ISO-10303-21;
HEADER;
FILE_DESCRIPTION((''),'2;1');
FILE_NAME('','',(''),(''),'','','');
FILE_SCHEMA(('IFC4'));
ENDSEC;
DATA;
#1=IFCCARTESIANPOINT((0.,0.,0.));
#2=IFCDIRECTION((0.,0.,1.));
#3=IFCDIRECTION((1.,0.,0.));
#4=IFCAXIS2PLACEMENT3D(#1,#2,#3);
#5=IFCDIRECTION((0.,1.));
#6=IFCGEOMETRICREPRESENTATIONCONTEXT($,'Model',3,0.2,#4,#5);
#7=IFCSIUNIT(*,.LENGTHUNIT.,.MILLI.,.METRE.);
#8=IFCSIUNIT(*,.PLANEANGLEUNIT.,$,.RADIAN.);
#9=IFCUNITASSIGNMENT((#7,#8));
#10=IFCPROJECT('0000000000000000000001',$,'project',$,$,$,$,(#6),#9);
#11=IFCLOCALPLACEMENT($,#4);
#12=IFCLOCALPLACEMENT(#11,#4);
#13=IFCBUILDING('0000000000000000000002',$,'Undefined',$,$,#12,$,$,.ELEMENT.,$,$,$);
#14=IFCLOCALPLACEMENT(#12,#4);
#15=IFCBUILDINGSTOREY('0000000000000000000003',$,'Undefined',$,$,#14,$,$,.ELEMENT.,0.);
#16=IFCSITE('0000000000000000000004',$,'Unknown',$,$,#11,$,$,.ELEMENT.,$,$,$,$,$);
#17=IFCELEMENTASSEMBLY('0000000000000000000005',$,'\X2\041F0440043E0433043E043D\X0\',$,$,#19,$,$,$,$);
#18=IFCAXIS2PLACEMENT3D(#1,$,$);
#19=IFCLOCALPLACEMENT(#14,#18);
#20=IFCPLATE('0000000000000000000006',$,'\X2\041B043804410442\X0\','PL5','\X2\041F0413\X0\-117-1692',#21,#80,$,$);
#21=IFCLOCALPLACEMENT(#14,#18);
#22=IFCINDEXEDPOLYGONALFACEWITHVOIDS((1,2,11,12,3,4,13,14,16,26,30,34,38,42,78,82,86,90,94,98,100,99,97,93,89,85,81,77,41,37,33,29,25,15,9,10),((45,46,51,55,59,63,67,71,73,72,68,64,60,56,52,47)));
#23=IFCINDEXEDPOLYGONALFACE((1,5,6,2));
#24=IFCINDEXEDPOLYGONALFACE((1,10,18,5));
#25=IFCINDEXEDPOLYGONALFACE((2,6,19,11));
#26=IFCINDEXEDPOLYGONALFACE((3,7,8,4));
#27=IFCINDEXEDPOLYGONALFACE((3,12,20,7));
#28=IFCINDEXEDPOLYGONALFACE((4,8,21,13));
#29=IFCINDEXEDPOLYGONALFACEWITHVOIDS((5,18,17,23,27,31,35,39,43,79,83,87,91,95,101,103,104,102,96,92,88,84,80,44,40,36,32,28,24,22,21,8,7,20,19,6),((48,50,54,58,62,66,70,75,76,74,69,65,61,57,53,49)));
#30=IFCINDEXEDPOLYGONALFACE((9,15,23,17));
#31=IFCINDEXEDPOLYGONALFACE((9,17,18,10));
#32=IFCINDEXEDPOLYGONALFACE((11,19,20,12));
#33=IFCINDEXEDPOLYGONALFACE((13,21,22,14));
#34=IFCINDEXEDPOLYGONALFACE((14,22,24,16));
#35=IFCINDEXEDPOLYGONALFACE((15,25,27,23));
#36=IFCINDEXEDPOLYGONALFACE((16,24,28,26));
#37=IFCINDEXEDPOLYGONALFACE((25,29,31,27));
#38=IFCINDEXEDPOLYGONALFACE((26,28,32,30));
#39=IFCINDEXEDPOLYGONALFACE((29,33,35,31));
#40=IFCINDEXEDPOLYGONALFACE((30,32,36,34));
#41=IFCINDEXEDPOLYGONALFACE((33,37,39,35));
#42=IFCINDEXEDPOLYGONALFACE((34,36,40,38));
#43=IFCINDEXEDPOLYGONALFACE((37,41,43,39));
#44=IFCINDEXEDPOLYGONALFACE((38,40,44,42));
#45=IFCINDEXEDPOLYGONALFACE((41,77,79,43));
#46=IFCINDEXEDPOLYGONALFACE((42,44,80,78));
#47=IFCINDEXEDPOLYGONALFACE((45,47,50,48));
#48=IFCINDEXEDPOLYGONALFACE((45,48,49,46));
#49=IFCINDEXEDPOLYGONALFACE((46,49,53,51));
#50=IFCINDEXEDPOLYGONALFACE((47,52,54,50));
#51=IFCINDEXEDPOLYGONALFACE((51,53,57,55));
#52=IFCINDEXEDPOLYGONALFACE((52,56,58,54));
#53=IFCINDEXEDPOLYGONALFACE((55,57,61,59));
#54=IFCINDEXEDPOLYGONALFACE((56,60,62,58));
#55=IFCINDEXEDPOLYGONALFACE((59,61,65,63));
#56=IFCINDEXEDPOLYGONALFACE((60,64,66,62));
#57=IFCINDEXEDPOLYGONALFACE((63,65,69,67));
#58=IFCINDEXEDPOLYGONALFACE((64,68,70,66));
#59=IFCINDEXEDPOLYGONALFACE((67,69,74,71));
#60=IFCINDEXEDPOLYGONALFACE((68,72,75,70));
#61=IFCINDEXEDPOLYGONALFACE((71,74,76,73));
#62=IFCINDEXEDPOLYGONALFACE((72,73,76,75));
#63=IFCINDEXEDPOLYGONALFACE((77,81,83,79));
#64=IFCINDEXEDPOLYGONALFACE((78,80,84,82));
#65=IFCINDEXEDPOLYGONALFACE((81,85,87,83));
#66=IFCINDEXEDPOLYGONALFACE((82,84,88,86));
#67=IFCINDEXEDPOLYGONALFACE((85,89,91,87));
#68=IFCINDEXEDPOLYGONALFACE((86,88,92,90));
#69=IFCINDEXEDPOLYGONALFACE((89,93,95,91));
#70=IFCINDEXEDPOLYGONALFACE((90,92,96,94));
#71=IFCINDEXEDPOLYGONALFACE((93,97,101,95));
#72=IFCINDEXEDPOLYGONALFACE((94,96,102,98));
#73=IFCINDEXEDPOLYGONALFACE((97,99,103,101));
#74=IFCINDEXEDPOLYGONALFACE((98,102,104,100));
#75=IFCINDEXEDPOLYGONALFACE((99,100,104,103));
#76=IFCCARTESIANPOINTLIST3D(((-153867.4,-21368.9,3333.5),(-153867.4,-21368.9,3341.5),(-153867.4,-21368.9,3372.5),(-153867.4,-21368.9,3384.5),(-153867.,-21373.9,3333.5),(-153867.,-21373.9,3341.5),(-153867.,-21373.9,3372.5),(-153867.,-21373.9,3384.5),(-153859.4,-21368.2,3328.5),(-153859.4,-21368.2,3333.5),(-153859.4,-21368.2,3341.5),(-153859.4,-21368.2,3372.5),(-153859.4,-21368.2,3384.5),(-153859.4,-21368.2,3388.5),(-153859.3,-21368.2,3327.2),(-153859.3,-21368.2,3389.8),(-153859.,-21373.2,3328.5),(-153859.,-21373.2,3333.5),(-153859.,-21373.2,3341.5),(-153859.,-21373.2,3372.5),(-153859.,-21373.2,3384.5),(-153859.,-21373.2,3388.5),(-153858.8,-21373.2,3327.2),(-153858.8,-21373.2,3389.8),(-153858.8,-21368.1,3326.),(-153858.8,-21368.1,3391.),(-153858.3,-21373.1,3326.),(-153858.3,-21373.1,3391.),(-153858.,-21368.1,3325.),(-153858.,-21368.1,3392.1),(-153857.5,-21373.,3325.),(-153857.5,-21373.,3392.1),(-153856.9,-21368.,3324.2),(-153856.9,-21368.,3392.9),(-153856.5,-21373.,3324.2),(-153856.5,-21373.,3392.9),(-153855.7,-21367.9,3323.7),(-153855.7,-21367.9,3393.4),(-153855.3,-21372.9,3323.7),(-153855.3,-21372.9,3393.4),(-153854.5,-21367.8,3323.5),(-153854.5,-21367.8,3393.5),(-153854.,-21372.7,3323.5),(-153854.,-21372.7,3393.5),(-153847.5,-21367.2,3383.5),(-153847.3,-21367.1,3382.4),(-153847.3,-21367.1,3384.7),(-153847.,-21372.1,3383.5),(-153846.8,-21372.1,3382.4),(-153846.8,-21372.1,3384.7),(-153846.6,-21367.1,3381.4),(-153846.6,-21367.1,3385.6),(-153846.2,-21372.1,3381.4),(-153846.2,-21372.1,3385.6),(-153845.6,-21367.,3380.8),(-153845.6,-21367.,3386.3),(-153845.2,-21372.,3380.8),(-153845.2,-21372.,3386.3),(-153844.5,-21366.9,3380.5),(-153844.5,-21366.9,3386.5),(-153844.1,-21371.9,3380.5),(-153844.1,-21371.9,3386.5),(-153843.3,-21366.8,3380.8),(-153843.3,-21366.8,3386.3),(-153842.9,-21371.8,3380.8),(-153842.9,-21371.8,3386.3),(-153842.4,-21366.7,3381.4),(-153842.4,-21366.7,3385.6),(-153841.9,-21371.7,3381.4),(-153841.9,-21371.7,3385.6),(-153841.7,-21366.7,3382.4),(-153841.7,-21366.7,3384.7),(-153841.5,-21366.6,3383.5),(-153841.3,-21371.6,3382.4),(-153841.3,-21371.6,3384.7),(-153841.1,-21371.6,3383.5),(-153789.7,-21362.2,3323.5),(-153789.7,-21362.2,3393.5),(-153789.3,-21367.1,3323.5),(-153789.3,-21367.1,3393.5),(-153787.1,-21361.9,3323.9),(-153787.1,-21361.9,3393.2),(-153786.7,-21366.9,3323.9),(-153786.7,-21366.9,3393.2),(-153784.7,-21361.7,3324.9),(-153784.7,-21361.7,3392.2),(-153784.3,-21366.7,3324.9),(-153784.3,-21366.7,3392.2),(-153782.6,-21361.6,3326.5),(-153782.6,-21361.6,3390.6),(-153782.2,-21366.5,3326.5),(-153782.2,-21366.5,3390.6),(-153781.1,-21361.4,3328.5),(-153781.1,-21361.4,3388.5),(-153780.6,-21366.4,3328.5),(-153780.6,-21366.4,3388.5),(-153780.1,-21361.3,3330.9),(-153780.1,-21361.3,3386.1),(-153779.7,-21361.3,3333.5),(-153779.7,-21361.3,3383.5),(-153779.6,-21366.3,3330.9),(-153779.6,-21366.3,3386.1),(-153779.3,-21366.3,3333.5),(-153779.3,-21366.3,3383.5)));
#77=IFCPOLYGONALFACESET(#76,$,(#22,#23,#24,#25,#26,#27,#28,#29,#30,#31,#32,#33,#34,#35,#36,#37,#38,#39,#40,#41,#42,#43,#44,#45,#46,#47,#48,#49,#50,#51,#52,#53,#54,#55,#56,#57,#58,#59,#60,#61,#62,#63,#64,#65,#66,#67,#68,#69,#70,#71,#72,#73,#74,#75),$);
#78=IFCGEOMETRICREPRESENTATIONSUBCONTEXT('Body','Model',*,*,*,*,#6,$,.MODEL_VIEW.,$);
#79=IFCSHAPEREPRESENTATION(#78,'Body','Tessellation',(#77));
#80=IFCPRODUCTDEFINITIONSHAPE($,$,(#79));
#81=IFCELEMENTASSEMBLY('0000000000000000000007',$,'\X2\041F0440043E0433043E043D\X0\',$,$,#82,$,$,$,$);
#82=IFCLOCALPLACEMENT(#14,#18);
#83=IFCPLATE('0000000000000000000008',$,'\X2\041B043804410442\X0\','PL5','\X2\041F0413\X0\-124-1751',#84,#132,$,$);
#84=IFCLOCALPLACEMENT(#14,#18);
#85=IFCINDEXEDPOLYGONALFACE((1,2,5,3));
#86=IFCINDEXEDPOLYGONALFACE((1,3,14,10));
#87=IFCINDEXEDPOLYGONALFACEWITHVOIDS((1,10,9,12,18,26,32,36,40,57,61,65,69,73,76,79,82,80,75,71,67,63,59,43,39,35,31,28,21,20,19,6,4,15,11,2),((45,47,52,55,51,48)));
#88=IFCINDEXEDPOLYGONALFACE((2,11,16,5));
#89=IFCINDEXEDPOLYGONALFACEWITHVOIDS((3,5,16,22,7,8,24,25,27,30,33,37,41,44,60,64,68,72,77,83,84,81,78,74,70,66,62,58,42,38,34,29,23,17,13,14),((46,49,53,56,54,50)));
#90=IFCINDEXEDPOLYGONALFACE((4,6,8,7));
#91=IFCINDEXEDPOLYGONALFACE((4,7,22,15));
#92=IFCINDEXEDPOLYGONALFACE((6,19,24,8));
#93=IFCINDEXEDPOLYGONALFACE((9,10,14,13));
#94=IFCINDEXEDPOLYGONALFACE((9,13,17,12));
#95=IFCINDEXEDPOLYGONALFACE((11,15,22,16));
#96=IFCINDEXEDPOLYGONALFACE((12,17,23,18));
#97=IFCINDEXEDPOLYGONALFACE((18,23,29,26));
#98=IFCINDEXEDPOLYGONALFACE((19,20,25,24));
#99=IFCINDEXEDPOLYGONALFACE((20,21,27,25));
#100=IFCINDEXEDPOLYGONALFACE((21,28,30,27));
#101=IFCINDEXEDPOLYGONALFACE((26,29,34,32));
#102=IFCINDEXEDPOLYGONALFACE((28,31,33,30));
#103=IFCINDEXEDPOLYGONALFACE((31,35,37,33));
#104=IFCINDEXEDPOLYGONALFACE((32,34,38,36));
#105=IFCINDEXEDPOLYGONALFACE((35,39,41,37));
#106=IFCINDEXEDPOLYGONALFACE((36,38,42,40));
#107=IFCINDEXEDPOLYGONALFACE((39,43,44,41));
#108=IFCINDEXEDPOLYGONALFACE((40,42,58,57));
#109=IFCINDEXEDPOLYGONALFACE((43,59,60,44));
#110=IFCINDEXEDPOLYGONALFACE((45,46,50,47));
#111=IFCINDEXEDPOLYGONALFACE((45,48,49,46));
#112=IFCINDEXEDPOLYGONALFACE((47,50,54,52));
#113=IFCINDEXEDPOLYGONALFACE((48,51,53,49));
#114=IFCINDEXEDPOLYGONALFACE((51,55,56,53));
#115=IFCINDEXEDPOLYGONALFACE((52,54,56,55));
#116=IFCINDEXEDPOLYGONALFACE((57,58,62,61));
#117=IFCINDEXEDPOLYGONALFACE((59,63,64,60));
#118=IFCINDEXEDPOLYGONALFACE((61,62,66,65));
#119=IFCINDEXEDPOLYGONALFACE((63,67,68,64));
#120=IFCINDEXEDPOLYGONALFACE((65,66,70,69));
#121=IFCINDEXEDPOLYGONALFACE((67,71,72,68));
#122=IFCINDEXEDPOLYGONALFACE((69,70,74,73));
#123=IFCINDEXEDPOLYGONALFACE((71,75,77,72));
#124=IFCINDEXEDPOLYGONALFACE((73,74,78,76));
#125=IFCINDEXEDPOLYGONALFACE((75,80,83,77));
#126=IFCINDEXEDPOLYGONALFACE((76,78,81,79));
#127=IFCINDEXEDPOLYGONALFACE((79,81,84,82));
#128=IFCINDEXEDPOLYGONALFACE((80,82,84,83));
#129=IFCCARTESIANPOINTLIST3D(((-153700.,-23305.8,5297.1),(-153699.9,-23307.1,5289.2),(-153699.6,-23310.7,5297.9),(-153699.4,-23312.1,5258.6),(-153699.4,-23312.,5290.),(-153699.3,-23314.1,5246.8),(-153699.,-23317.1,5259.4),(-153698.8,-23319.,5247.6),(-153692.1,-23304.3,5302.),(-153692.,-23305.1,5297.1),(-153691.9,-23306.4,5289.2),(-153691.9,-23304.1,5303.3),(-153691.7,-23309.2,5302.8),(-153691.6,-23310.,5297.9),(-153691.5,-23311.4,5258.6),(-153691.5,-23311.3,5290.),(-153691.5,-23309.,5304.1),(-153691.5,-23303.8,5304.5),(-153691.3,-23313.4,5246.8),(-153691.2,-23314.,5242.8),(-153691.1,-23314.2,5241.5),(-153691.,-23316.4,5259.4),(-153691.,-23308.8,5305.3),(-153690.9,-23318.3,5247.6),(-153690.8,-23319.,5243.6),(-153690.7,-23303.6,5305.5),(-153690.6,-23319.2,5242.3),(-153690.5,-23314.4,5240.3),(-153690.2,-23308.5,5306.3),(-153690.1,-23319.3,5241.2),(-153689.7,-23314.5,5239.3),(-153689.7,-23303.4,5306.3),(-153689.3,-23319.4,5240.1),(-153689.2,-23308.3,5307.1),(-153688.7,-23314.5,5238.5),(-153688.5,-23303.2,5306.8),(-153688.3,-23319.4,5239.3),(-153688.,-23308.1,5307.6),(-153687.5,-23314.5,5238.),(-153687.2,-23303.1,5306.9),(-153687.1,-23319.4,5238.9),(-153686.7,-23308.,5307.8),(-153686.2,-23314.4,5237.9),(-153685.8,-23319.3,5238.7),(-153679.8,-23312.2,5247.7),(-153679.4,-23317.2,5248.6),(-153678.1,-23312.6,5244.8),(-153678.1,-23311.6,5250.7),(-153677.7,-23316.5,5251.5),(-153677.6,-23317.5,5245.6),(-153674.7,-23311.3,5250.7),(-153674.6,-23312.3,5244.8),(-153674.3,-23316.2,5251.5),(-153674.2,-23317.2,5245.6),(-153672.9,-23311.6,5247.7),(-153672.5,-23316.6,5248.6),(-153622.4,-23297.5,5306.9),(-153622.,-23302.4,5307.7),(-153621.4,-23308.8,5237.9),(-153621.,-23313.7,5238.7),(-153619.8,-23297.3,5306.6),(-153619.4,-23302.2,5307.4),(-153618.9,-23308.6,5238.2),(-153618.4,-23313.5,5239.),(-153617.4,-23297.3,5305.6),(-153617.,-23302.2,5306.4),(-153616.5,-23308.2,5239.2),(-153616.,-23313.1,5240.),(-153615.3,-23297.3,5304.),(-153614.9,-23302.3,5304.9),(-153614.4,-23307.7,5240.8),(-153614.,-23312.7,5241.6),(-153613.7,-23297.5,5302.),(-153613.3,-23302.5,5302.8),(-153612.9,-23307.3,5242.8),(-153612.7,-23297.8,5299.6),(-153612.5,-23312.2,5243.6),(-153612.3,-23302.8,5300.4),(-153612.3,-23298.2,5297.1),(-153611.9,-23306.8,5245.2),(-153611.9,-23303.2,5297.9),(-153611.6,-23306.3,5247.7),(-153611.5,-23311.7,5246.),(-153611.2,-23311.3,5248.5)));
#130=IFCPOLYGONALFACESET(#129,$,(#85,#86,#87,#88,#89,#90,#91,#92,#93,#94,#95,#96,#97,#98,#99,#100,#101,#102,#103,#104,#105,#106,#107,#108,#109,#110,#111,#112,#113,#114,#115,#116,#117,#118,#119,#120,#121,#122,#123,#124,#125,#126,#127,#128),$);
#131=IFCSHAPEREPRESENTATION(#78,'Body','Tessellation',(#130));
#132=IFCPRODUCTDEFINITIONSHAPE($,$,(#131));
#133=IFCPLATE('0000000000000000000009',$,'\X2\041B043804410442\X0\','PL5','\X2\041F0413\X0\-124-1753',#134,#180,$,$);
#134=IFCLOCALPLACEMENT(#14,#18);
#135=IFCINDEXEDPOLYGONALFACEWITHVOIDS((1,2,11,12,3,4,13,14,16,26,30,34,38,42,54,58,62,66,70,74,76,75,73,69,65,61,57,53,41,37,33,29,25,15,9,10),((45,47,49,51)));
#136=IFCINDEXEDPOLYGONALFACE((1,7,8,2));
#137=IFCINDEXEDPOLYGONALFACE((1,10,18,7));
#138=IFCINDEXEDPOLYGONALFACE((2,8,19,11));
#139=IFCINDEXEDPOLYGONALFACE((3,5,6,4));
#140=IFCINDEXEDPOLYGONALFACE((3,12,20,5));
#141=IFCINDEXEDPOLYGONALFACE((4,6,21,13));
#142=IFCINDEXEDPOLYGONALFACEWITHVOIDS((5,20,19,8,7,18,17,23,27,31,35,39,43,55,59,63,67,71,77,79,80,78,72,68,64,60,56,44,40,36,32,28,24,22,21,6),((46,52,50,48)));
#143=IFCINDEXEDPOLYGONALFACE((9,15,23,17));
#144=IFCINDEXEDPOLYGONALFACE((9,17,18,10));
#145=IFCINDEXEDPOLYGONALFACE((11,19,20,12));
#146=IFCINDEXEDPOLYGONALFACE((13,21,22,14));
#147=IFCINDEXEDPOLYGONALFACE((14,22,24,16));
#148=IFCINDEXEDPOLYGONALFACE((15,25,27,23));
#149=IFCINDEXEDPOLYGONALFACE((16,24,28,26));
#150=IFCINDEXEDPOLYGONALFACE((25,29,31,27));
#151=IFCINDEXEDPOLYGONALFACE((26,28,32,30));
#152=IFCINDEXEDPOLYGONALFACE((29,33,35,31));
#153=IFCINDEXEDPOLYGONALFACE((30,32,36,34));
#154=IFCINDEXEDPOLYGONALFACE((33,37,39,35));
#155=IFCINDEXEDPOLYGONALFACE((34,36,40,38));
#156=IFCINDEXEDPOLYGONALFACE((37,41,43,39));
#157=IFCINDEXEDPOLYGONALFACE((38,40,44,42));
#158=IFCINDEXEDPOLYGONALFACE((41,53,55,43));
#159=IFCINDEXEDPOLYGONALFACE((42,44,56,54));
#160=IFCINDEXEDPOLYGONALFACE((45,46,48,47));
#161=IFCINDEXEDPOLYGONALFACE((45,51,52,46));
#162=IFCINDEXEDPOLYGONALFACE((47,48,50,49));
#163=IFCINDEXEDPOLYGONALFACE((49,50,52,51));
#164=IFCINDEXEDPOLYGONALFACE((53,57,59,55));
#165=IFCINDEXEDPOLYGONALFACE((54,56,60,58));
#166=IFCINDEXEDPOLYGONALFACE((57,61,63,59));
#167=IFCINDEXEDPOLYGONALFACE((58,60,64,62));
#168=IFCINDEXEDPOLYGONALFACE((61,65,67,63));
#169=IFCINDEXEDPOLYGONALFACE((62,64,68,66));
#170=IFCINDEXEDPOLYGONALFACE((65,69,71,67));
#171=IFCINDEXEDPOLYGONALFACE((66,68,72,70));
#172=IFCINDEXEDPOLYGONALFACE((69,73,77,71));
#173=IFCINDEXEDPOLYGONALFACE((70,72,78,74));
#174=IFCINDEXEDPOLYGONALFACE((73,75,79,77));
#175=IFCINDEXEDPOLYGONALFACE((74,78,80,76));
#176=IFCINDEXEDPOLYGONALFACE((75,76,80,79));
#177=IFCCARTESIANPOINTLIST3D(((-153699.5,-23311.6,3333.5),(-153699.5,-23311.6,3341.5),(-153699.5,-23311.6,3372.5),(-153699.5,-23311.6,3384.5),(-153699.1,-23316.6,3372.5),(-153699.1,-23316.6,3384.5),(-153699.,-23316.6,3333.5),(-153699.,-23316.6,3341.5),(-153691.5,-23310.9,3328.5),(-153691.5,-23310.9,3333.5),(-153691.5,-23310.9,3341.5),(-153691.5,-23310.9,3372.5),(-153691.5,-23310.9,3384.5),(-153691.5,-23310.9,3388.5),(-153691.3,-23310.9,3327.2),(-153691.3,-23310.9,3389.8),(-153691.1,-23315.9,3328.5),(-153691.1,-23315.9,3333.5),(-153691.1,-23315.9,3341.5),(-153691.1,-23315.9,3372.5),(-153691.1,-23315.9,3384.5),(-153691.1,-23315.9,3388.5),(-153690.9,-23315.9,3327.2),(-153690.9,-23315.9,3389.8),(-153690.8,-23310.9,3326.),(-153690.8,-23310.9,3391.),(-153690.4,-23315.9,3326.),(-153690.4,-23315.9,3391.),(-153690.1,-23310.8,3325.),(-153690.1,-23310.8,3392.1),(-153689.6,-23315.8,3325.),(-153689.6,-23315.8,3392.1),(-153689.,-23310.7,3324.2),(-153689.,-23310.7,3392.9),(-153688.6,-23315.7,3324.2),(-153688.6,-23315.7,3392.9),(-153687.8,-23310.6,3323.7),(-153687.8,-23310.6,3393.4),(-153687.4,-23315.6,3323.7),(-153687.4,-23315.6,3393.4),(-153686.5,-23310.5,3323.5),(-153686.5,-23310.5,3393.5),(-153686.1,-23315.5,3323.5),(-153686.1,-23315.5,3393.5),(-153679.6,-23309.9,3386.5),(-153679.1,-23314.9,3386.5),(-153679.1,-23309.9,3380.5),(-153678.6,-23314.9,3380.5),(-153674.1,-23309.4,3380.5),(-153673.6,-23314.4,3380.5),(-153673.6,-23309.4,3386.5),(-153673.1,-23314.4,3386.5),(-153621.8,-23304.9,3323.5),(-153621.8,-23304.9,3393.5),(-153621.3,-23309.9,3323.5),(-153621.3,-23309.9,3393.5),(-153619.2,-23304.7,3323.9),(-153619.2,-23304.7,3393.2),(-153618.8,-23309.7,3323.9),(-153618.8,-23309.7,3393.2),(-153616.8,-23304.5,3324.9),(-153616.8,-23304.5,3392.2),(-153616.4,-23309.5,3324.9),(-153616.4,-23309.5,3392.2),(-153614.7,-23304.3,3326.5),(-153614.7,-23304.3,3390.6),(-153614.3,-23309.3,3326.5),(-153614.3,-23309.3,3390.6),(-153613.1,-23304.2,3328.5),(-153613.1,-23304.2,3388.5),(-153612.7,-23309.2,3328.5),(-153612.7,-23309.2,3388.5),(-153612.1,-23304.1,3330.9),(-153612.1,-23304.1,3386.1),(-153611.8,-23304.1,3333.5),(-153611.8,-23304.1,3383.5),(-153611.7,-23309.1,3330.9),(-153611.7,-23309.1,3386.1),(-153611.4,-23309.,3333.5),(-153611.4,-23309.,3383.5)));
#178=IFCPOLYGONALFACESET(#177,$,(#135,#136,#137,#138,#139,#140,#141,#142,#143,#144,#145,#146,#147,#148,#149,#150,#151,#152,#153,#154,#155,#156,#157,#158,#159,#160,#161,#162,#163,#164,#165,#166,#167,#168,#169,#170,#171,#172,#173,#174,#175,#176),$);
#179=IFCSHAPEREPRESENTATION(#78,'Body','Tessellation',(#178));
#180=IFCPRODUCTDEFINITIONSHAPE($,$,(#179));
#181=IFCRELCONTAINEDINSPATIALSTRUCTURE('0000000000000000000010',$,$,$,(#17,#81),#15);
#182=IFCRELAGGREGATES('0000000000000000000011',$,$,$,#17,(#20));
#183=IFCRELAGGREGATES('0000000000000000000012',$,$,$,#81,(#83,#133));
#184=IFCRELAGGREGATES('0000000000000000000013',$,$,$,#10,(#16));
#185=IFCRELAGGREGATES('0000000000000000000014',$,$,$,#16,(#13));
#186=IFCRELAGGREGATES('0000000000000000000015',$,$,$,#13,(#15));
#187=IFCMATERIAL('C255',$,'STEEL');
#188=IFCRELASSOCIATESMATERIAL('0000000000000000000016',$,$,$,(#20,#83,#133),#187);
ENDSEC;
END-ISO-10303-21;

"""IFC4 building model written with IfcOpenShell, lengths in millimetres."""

from ifc_helpers import new_model, si_unit, direction, frame, origin_with_axes, place, context, subcontext, project, spatial, line, arc, indexed_curve, outline, extrude, material, element, aggregate, save


model = new_model("IFC4")

# Units and contexts
model_context = context("Model", 3, precision=0.2, world=origin_with_axes(), true_north=direction((0.0, 1.0)))
body_context = subcontext(model_context, "Body", "Model", "MODEL_VIEW")
ifc_project = project(units=[si_unit("LENGTHUNIT", "METRE", prefix="MILLI"), si_unit("PLANEANGLEUNIT", "RADIAN")], contexts=[model_context])

# Site, building, storey
site_placement = place(None, origin_with_axes())
site = spatial("IfcSite", under=ifc_project, at=site_placement, Name="Unknown", CompositionType="ELEMENT")
building_placement = place(site_placement, origin_with_axes())
building = spatial("IfcBuilding", under=site, at=building_placement, Name="Undefined", CompositionType="ELEMENT")
storey_placement = place(building_placement, origin_with_axes())
storey = spatial("IfcBuildingStorey", under=building, at=storey_placement, Name="Undefined", CompositionType="ELEMENT", Elevation=0.0)

# Shared definitions
ifc_material_1 = material(Name="C255", Category="STEEL")

# Element assemblies, plates, voiding features
assembly_1_placement = place(storey_placement, frame((-153899.1, -21374.1, 3248.5), z_axis=(0.086114, -0.996285, 0.0), x_axis=(0.0, 0.0, 1.0)))
assembly_1 = element("IfcElementAssembly", 1, at=assembly_1_placement, inside=storey, Name="Прогон")
plate_1_placement = place(assembly_1_placement, frame((75.0, -120.0, 0.0), z_axis=(0.0, -0.000057, 1.0), x_axis=(1.0, 0.000078, 0.0)))
plate_1 = element("IfcPlate", 2, at=plate_1_placement, material=ifc_material_1, Name="Лист", Description="PL5", ObjectType="ПГ-117-1692", context=body_context, shape_type="SolidModel", body=[
    extrude(outline(indexed_curve([(0.0, 10.0), (2.9, 2.9), (10.0, 0.0), (60.0, 0.0), (67.1, 2.9), (70.0, 10.0), (70.0, 75.0), (68.5, 78.5), (65.0, 80.0), (61.0, 80.0), (61.0, 88.0), (49.0, 88.0), (49.0, 80.0), (18.0, 80.0), (18.0, 88.0), (10.0, 88.0), (10.0, 80.0), (5.0, 80.0), (1.5, 78.5), (0.0, 75.0)], segments=[arc(1, 2, 3), line(3, 4), arc(4, 5, 6), line(6, 7), arc(7, 8, 9), line(9, 10, 11, 12, 13, 14, 15, 16, 17, 18), arc(18, 19, 20), line(20, 1)])), frame((0.0, 0.0, 2.5), z_axis=(0.0, 0.0, 1.0), x_axis=(1.0, 0.0, 0.0)), (0.0, 0.0, -1.0), 5.0),
])
voiding_feature_1_placement = place(plate_1_placement, frame((60.0, 65.0, 6.0), z_axis=(-0.000054, -1.0, 0.000034), x_axis=(0.0, -0.000034, -1.0)))
element("IfcVoidingFeature", 3, at=voiding_feature_1_placement, cuts=plate_1, Name="Балка", ObjectType="(?)", PredefinedType="HOLE", context=body_context, shape_type="SolidModel", body=[
    extrude(outline(indexed_curve([(3.0, 0.0), (2.8, 1.1), (2.1, 2.1), (1.1, 2.8), (0.0, 3.0), (-1.1, 2.8), (-2.1, 2.1), (-2.8, 1.1), (-3.0, 0.0), (-2.8, -1.1), (-2.1, -2.1), (-1.1, -2.8), (0.0, -3.0), (1.1, -2.8), (2.1, -2.1), (2.8, -1.1)], segments=[line(1, 2, 3, 4, 5, 6, 7, 8, 9, 10, 11, 12, 13, 14, 15, 16, 1)])), frame((0.0, 0.0, 0.0), z_axis=(-1.0, 0.0, 0.0), x_axis=(0.0, 0.0, 1.0)), (0.0, 0.0, -1.0), 12.0),
])
assembly_2_placement = place(storey_placement, frame((-153731.1, -23316.9, 3248.5), z_axis=(0.086114, -0.996285, 0.0), x_axis=(0.0, 0.0, 1.0)))
assembly_2 = element("IfcElementAssembly", 4, at=assembly_2_placement, inside=storey, Name="Прогон")
plate_2_placement = place(assembly_2_placement, frame((2058.8, -120.0, -7.5), z_axis=(-0.162881, -0.000054, -0.986646), x_axis=(-0.986646, 0.000078, 0.162881)))
plate_2 = element("IfcPlate", 5, at=plate_2_placement, material=ifc_material_1, Name="Лист", Description="PL5", ObjectType="ПГ-124-1751", context=body_context, shape_type="SolidModel", body=[
    extrude(outline(indexed_curve([(0.0, 10.0), (2.9, 2.9), (10.0, 0.0), (60.0, 0.0), (67.1, 2.9), (70.0, 10.0), (70.0, 75.0), (68.5, 78.5), (65.0, 80.0), (61.0, 80.0), (61.0, 88.0), (49.0, 88.0), (49.0, 80.0), (18.0, 80.0), (18.0, 88.0), (10.0, 88.0), (10.0, 80.0), (5.0, 80.0), (1.5, 78.5), (0.0, 75.0)], segments=[arc(1, 2, 3), line(3, 4), arc(4, 5, 6), line(6, 7), arc(7, 8, 9), line(9, 10, 11, 12, 13, 14, 15, 16, 17, 18), arc(18, 19, 20), line(20, 1)])), frame((0.0, 0.0, 2.5), z_axis=(0.0, 0.0, 1.0), x_axis=(1.0, 0.0, 0.0)), (0.0, 0.0, -1.0), 5.0),
])
voiding_feature_2_placement = place(plate_2_placement, frame((60.0, 65.0, 6.0), z_axis=(-0.000054, -1.0, 0.000034), x_axis=(0.0, -0.000034, -1.0)))
element("IfcVoidingFeature", 6, at=voiding_feature_2_placement, cuts=plate_2, Name="Балка", ObjectType="(?)", PredefinedType="HOLE", context=body_context, shape_type="SolidModel", body=[
    extrude(outline(indexed_curve([(1.7, -3.0), (3.5, 0.0), (1.7, 3.0), (-1.7, 3.0), (-3.5, 0.0), (-1.7, -3.0)], segments=[line(1, 2, 3, 4, 5, 6, 1)])), frame((0.0, 0.0, 0.0), z_axis=(-1.0, 0.0, 0.0), x_axis=(0.0, 0.0, 1.0)), (0.0, 0.0, -1.0), 12.0),
])
plate_3_placement = place(assembly_2_placement, frame((75.0, -120.0, 0.0), z_axis=(0.0, -0.000057, 1.0), x_axis=(1.0, 0.000078, 0.0)))
plate_3 = element("IfcPlate", 7, at=plate_3_placement, material=ifc_material_1, Name="Лист", Description="PL5", ObjectType="ПГ-124-1753", context=body_context, shape_type="SolidModel", body=[
    extrude(outline(indexed_curve([(0.0, 10.0), (2.9, 2.9), (10.0, 0.0), (60.0, 0.0), (67.1, 2.9), (70.0, 10.0), (70.0, 75.0), (68.5, 78.5), (65.0, 80.0), (61.0, 80.0), (61.0, 88.0), (49.0, 88.0), (49.0, 80.0), (18.0, 80.0), (18.0, 88.0), (10.0, 88.0), (10.0, 80.0), (5.0, 80.0), (1.5, 78.5), (0.0, 75.0)], segments=[arc(1, 2, 3), line(3, 4), arc(4, 5, 6), line(6, 7), arc(7, 8, 9), line(9, 10, 11, 12, 13, 14, 15, 16, 17, 18), arc(18, 19, 20), line(20, 1)])), frame((0.0, 0.0, 2.5), z_axis=(0.0, 0.0, 1.0), x_axis=(1.0, 0.0, 0.0)), (0.0, 0.0, -1.0), 5.0),
])
voiding_feature_3_placement = place(plate_3_placement, frame((60.0, 65.0, 6.0), z_axis=(-0.000054, -1.0, 0.000034), x_axis=(0.0, -0.000034, -1.0)))
element("IfcVoidingFeature", 8, at=voiding_feature_3_placement, cuts=plate_3, Name="Балка", ObjectType="(?)", PredefinedType="HOLE", context=body_context, shape_type="SolidModel", body=[
    extrude(outline(indexed_curve([(2.5, -3.0), (3.0, 3.0), (-3.0, 3.0), (-2.5, -3.0)], segments=[line(1, 2, 3, 4, 1)])), frame((0.0, 0.0, 0.0), z_axis=(-1.0, 0.0, 0.0), x_axis=(0.0, 0.0, 1.0)), (0.0, 0.0, -1.0), 12.0),
])

aggregate(assembly_1, [plate_1])
aggregate(assembly_2, [plate_2, plate_3])

save(model, "model.ifc")
